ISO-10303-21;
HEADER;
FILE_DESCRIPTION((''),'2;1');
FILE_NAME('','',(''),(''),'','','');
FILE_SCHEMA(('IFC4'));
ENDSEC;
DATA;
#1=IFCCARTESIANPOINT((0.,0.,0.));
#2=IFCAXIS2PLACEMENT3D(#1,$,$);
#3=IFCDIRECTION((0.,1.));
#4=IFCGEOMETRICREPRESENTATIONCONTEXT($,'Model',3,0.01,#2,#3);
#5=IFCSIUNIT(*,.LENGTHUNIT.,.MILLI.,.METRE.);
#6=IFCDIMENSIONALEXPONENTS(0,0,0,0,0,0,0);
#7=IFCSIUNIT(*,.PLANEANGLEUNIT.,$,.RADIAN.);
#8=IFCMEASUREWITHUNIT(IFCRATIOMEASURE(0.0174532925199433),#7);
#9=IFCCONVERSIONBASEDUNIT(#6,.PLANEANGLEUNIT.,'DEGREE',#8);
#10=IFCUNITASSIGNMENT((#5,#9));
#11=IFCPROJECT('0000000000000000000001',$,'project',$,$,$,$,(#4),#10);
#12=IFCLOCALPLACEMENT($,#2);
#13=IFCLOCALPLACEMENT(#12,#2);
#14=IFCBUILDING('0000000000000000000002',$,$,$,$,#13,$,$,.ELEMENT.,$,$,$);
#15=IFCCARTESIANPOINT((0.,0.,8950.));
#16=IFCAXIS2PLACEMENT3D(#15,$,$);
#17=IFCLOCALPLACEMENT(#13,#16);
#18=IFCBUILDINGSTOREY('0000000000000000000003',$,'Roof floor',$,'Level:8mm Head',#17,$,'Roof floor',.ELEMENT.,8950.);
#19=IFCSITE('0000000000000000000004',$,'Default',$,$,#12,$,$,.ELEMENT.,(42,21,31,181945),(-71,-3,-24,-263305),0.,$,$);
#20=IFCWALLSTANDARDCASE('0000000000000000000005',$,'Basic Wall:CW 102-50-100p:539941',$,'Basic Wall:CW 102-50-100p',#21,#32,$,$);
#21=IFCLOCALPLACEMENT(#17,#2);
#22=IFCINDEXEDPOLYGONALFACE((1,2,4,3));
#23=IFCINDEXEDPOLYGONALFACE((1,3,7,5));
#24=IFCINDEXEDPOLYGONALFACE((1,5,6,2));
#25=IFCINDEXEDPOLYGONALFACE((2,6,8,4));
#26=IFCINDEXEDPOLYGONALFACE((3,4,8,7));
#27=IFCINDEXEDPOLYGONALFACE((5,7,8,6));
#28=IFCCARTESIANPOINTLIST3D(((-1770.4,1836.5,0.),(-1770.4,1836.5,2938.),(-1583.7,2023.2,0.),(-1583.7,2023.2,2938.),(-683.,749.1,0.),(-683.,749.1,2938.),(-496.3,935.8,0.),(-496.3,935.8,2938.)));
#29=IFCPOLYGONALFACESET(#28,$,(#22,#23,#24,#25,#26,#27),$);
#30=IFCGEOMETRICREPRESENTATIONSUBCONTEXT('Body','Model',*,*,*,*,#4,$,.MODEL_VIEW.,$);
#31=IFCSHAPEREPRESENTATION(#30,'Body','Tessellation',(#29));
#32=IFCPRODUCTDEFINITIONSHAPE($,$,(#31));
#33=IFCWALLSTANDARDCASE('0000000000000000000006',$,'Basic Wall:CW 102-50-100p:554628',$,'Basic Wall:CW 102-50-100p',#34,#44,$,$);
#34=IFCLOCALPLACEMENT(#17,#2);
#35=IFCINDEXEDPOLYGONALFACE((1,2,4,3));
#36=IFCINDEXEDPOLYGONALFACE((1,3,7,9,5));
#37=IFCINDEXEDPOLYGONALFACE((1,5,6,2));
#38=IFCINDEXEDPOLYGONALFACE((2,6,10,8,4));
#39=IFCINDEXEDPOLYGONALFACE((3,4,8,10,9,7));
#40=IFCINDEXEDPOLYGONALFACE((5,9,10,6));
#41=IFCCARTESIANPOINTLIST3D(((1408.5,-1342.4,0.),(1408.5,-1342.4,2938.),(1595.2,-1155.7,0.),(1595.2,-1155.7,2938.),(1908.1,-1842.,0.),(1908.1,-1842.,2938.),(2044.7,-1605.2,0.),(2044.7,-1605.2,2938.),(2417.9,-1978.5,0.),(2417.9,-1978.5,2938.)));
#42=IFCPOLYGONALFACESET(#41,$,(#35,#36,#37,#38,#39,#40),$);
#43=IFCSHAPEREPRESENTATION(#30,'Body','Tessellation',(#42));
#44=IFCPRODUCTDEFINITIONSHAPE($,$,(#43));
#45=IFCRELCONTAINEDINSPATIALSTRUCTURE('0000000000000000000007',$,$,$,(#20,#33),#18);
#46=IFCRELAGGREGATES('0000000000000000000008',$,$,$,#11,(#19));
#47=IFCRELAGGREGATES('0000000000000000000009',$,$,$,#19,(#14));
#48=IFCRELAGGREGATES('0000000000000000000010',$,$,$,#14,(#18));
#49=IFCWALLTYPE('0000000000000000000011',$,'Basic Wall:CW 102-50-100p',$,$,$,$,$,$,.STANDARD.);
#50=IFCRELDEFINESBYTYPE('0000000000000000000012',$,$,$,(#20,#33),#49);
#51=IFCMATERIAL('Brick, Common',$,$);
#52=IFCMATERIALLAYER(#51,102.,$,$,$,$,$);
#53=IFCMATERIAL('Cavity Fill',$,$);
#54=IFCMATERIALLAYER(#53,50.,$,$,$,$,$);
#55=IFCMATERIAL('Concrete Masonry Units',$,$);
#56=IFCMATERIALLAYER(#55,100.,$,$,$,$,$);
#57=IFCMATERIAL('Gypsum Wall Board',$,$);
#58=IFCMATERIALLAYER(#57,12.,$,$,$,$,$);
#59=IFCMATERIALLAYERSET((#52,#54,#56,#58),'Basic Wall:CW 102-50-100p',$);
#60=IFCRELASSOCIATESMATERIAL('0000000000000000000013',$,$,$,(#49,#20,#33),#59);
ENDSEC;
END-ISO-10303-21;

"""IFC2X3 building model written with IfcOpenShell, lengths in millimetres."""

from ifc_helpers import new_model, entity, si_unit, converted_unit, direction, frame, frame_2d, origin, place, context, subcontext, project, spatial, polyline, rectangle, outline, extrude, material, layer, layer_set, layer_usage, type_object, element, save


model = new_model("IFC2X3")

# Units and contexts
model_context = context("Model", 3, precision=0.01, world=origin(), true_north=direction((0.0, 1.0)))
body_context = subcontext(model_context, "Body", "Model", "MODEL_VIEW")
ifc_project = project(units=[si_unit("LENGTHUNIT", "METRE", prefix="MILLI"), converted_unit("PLANEANGLEUNIT", "DEGREE", entity("IfcRatioMeasure", 0.0174532925199433), si_unit("PLANEANGLEUNIT", "RADIAN"), dimensions=[0, 0, 0, 0, 0, 0, 0])], contexts=[model_context])

# Site, building, storey
site_placement = place(None, origin())
site = spatial("IfcSite", under=ifc_project, at=site_placement, Name="Default", CompositionType="ELEMENT", RefLatitude=(42, 21, 31, 181945), RefLongitude=(-71, -3, -24, -263305), RefElevation=0.0)
building_placement = place(site_placement, origin())
building = spatial("IfcBuilding", under=site, at=building_placement, CompositionType="ELEMENT")
storey_placement = place(building_placement, frame((0.0, 0.0, 8950.0)))
storey = spatial("IfcBuildingStorey", under=building, at=storey_placement, Name="Roof floor", ObjectType="Level:8mm Head", LongName="Roof floor", CompositionType="ELEMENT", Elevation=8950.0)

# Walls
ifc_material_1 = material(Name="Brick, Common")
ifc_layer_1 = layer(ifc_material_1, 102.0)
ifc_material_2 = material(Name="Cavity Fill")
ifc_layer_2 = layer(ifc_material_2, 50.0)
ifc_material_3 = material(Name="Concrete Masonry Units")
ifc_layer_3 = layer(ifc_material_3, 100.0)
ifc_material_4 = material(Name="Gypsum Wall Board")
ifc_layer_4 = layer(ifc_material_4, 12.0)
ifc_layer_set_1 = layer_set([ifc_layer_1, ifc_layer_2, ifc_layer_3, ifc_layer_4], Name="Basic Wall:CW 102-50-100p")
ifc_layer_usage_1 = layer_usage(ifc_layer_set_1, "AXIS2", "NEGATIVE", 132.0)
wall_type = type_object("IfcWallType", Name="Basic Wall:CW 102-50-100p", PredefinedType="STANDARD", material=ifc_layer_set_1)
wall_1_placement = place(storey_placement, frame((-1677.1, 1929.9, 0.0), z_axis=(0.0, 0.0, 1.0), x_axis=(0.707107, -0.707107, 0.0)))
element("IfcWallStandardCase", 1, at=wall_1_placement, inside=storey, type_object=wall_type, material=ifc_layer_usage_1, Name="Basic Wall:CW 102-50-100p:539941", ObjectType="Basic Wall:CW 102-50-100p", context=body_context, shape_type="SweptSolid", body=[
    extrude(rectangle(XDim=1537.8, YDim=264.0, at=frame_2d((768.9, 0.0), x_axis=(-1.0, 0.0))), origin(), (0.0, 0.0, 1.0), 2938.0),
])
ifc_layer_usage_2 = layer_usage(ifc_layer_set_1, "AXIS2", "NEGATIVE", 132.0)
wall_2_placement = place(storey_placement, frame((1501.9, -1249.1, 0.0), z_axis=(0.0, 0.0, 1.0), x_axis=(0.707107, -0.707107, 0.0)))
element("IfcWallStandardCase", 2, at=wall_2_placement, inside=storey, type_object=wall_type, material=ifc_layer_usage_2, Name="Basic Wall:CW 102-50-100p:554628", ObjectType="Basic Wall:CW 102-50-100p", context=body_context, shape_type="SweptSolid", body=[
    extrude(outline(polyline([(706.5, -132.0), (1163.5, 132.0), (635.7, 132.0), (0.0, 132.0), (0.0, -132.0), (706.5, -132.0)])), origin(), (0.0, 0.0, 1.0), 2938.0),
])

save(model, "model.ifc")
